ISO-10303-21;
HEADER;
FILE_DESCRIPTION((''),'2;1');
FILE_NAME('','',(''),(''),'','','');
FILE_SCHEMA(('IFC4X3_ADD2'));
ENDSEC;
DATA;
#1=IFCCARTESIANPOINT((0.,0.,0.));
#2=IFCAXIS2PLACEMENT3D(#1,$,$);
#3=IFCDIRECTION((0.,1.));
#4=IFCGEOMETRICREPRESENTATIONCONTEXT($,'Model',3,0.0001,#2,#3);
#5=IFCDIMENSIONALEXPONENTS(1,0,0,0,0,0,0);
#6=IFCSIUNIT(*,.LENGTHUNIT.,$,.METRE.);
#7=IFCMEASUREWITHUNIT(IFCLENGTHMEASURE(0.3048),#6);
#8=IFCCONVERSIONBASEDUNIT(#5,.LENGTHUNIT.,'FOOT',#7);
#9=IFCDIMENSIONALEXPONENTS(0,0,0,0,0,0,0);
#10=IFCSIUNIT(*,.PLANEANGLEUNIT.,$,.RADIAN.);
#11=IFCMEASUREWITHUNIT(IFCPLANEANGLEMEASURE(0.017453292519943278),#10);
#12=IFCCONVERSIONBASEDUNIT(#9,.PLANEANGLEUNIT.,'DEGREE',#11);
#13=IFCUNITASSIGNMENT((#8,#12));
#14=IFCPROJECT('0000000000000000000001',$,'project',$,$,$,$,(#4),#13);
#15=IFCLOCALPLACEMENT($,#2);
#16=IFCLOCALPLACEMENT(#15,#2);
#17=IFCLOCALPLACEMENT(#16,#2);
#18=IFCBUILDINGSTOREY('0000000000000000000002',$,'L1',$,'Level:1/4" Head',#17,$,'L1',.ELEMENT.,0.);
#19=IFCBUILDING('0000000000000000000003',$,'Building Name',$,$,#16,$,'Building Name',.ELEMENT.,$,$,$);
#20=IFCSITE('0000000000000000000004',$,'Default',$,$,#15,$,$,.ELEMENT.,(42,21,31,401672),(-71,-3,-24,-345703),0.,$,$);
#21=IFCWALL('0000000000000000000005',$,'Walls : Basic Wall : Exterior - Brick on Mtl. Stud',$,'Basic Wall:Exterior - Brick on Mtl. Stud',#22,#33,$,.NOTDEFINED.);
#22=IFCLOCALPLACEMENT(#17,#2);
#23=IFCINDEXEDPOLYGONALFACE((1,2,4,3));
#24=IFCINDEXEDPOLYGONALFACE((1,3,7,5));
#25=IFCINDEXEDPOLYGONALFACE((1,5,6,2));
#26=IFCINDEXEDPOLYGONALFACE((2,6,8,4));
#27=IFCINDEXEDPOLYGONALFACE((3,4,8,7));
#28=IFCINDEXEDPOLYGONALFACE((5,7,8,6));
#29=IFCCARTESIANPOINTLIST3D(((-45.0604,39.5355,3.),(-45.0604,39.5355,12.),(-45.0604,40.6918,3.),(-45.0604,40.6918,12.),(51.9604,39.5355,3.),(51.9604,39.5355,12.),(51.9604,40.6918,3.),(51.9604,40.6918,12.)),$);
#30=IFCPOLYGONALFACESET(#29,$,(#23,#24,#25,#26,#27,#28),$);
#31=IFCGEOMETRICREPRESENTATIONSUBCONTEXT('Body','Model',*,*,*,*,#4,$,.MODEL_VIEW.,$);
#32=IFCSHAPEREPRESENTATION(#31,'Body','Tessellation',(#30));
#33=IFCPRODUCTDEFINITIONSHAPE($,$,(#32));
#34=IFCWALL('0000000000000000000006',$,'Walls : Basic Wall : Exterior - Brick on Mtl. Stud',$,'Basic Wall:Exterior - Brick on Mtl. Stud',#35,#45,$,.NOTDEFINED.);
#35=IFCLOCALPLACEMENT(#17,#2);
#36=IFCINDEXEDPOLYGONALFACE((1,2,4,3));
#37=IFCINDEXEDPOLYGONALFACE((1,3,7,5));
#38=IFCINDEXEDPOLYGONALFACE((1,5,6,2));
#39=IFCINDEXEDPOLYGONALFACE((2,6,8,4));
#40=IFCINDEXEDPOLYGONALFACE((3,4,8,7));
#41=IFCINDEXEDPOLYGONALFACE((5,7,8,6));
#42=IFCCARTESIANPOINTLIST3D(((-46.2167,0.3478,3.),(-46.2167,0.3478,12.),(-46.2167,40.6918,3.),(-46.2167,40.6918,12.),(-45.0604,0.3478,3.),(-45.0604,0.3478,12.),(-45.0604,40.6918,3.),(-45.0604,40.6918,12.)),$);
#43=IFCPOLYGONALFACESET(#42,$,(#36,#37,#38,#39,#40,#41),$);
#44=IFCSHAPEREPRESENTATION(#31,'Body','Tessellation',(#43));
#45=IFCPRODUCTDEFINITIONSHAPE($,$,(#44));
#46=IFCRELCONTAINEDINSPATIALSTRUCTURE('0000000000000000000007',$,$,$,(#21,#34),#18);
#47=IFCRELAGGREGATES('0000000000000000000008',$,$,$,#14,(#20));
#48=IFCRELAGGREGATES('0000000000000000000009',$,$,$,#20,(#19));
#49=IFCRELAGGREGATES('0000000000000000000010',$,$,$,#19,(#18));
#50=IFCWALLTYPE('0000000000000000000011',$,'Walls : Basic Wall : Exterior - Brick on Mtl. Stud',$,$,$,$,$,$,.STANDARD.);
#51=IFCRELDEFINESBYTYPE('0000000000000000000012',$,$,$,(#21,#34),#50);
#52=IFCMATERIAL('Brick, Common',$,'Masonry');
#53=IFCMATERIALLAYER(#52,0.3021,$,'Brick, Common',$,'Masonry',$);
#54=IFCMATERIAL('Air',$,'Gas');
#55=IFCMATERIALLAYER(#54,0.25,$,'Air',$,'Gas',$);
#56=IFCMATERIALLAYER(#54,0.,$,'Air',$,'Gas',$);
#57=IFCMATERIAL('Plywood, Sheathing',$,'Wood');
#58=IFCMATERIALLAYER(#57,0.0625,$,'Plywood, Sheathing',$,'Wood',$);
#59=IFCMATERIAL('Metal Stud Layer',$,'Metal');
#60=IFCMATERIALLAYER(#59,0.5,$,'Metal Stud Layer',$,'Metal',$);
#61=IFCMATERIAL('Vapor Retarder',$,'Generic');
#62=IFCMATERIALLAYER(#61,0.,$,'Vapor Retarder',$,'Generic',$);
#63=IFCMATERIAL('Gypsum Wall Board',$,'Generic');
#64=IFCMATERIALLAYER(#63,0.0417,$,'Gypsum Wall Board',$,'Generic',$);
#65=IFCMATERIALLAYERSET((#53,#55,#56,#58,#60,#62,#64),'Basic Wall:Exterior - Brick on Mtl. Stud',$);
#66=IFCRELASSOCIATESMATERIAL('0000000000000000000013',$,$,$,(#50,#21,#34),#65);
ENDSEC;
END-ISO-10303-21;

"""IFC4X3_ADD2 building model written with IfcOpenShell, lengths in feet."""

from ifc_helpers import new_model, entity, si_unit, converted_unit, direction, frame, frame_2d, origin, place, context, subcontext, project, spatial, rectangle, extrude, material, layer, layer_set, type_object, element, save


model = new_model("IFC4X3_ADD2")

# Units and contexts
model_context = context("Model", 3, precision=0.0001, world=origin(), true_north=direction((0.0, 1.0)))
body_context = subcontext(model_context, "Body", "Model", "MODEL_VIEW")
ifc_project = project(units=[converted_unit("LENGTHUNIT", "FOOT", entity("IfcLengthMeasure", 0.3048), si_unit("LENGTHUNIT", "METRE"), dimensions=[1, 0, 0, 0, 0, 0, 0]), converted_unit("PLANEANGLEUNIT", "DEGREE", entity("IfcPlaneAngleMeasure", 0.017453292519943278), si_unit("PLANEANGLEUNIT", "RADIAN"), dimensions=[0, 0, 0, 0, 0, 0, 0])], contexts=[model_context])

# Site, building, storey
site_placement = place(None, origin())
site = spatial("IfcSite", under=ifc_project, at=site_placement, Name="Default", CompositionType="ELEMENT", RefLatitude=(42, 21, 31, 401672), RefLongitude=(-71, -3, -24, -345703), RefElevation=0.0)
building_placement = place(site_placement, origin())
building = spatial("IfcBuilding", under=site, at=building_placement, Name="Building Name", LongName="Building Name", CompositionType="ELEMENT")
storey_placement = place(building_placement, origin())
storey = spatial("IfcBuildingStorey", under=building, at=storey_placement, Name="L1", ObjectType="Level:1/4\" Head", LongName="L1", CompositionType="ELEMENT", Elevation=0.0)

# Walls
ifc_material_1 = material(Name="Air", Category="Gas")
ifc_material_2 = material(Name="Plywood, Sheathing", Category="Wood")
ifc_material_3 = material(Name="Metal Stud Layer", Category="Metal")
ifc_material_4 = material(Name="Vapor Retarder", Category="Generic")
ifc_material_5 = material(Name="Gypsum Wall Board", Category="Generic")
ifc_material_6 = material(Name="Brick, Common", Category="Masonry")
ifc_layer_1 = layer(ifc_material_6, 0.3021, Name="Brick, Common", Category="Masonry")
ifc_layer_2 = layer(ifc_material_1, 0.25, Name="Air", Category="Gas")
ifc_layer_3 = layer(ifc_material_1, 0.0, Name="Air", Category="Gas")
ifc_layer_4 = layer(ifc_material_2, 0.0625, Name="Plywood, Sheathing", Category="Wood")
ifc_layer_5 = layer(ifc_material_3, 0.5, Name="Metal Stud Layer", Category="Metal")
ifc_layer_6 = layer(ifc_material_4, 0.0, Name="Vapor Retarder", Category="Generic")
ifc_layer_7 = layer(ifc_material_5, 0.0417, Name="Gypsum Wall Board", Category="Generic")
ifc_layer_set_1 = layer_set([ifc_layer_1, ifc_layer_2, ifc_layer_3, ifc_layer_4, ifc_layer_5, ifc_layer_6, ifc_layer_7], Name="Basic Wall:Exterior - Brick on Mtl. Stud")
wall_type_1 = type_object("IfcWallType", Name="Walls : Basic Wall : Exterior - Brick on Mtl. Stud", PredefinedType="STANDARD", material=ifc_layer_set_1)
wall_1_placement = place(storey_placement, frame((-45.0604, 40.1136, 3.0)))
element("IfcWall", 1, at=wall_1_placement, inside=storey, type_object=wall_type_1, material=ifc_layer_set_1, Name="Walls : Basic Wall : Exterior - Brick on Mtl. Stud", ObjectType="Basic Wall:Exterior - Brick on Mtl. Stud", PredefinedType="NOTDEFINED", context=body_context, shape_type="SweptSolid", body=[
    extrude(rectangle(XDim=97.0208, YDim=1.1563, at=frame_2d((48.5104, 0.0), x_axis=(-1.0, 0.0))), origin(), (0.0, 0.0, 1.0), 9.0),
])
wall_2_placement = place(storey_placement, frame((-45.6385, 0.3478, 3.0), z_axis=(0.0, 0.0, 1.0), x_axis=(0.0, 1.0, 0.0)))
element("IfcWall", 2, at=wall_2_placement, inside=storey, type_object=wall_type_1, material=ifc_layer_set_1, Name="Walls : Basic Wall : Exterior - Brick on Mtl. Stud", ObjectType="Basic Wall:Exterior - Brick on Mtl. Stud", PredefinedType="NOTDEFINED", context=body_context, shape_type="SweptSolid", body=[
    extrude(rectangle(XDim=40.344, YDim=1.1562, at=frame_2d((20.172, 0.0), x_axis=(-1.0, 0.0))), origin(), (0.0, 0.0, 1.0), 9.0),
])

save(model, "model.ifc")
